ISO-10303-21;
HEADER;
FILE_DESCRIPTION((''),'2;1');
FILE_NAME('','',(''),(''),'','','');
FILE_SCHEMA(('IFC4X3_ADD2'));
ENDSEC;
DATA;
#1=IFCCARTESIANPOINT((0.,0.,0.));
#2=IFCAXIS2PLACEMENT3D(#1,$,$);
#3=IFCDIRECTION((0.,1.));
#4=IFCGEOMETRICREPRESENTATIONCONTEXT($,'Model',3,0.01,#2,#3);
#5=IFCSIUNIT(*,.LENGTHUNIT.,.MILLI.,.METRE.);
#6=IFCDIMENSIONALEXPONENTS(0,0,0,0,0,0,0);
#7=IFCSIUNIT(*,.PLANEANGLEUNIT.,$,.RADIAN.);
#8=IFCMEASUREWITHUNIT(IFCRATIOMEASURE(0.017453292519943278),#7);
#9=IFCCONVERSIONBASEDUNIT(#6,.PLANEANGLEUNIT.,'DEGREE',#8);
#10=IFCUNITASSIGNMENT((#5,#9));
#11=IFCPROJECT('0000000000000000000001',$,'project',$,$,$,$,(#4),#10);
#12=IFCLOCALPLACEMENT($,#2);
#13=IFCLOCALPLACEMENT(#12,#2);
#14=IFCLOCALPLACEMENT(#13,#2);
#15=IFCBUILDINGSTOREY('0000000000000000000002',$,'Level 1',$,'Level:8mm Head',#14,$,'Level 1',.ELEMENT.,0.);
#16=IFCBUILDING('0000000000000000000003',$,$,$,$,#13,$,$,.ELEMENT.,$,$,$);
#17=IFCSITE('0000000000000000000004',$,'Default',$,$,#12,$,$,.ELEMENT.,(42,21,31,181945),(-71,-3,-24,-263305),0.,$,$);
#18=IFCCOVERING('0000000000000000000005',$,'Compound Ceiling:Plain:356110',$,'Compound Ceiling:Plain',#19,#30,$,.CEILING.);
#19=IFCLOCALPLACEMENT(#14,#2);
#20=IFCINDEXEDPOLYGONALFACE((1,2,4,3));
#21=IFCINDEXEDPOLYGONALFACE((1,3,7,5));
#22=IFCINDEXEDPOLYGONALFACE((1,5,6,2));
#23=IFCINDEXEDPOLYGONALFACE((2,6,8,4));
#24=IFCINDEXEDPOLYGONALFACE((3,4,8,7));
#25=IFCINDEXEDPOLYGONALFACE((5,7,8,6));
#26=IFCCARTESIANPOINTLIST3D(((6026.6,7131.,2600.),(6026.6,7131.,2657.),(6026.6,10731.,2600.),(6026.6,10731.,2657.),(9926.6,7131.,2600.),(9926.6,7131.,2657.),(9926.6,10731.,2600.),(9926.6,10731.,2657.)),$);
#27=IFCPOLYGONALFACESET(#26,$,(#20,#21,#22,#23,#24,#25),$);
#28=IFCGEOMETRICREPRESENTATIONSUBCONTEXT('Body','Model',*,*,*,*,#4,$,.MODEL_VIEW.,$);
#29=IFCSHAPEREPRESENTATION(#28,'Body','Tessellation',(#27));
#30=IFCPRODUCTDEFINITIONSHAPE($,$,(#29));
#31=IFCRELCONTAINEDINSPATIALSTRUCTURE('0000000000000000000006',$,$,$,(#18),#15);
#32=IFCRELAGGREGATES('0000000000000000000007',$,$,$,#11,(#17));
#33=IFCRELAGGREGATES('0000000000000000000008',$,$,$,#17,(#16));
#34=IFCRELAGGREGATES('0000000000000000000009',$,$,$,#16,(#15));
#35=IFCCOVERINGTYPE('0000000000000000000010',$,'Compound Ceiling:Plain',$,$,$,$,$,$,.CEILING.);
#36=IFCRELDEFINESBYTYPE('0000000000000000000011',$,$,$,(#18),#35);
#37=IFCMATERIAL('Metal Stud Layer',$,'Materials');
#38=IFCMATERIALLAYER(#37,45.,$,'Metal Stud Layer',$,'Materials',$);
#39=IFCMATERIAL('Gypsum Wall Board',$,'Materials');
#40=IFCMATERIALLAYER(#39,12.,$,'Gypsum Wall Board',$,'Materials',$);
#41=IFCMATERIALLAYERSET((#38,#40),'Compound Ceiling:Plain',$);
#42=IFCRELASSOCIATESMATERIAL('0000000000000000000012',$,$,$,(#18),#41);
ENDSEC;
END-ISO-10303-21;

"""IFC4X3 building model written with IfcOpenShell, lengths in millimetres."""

from ifc_helpers import new_model, entity, si_unit, converted_unit, direction, frame, frame_2d, origin, place, context, subcontext, project, spatial, rectangle, extrude, material, layer, layer_set, layer_usage, type_object, element, save


model = new_model("IFC4X3")

# Units and contexts
model_context = context("Model", 3, precision=0.01, world=origin(), true_north=direction((0.0, 1.0)))
body_context = subcontext(model_context, "Body", "Model", "MODEL_VIEW")
ifc_project = project(units=[si_unit("LENGTHUNIT", "METRE", prefix="MILLI"), converted_unit("PLANEANGLEUNIT", "DEGREE", entity("IfcRatioMeasure", 0.017453292519943278), si_unit("PLANEANGLEUNIT", "RADIAN"), dimensions=[0, 0, 0, 0, 0, 0, 0])], contexts=[model_context])

# Site, building, storey
site_placement = place(None, origin())
site = spatial("IfcSite", under=ifc_project, at=site_placement, Name="Default", CompositionType="ELEMENT", RefLatitude=(42, 21, 31, 181945), RefLongitude=(-71, -3, -24, -263305), RefElevation=0.0)
building_placement = place(site_placement, origin())
building = spatial("IfcBuilding", under=site, at=building_placement, CompositionType="ELEMENT")
storey_placement = place(building_placement, origin())
storey = spatial("IfcBuildingStorey", under=building, at=storey_placement, Name="Level 1", ObjectType="Level:8mm Head", LongName="Level 1", CompositionType="ELEMENT", Elevation=0.0)

# Covering
ifc_material_1 = material(Name="Metal Stud Layer", Category="Materials")
ifc_layer_1 = layer(ifc_material_1, 45.0, Name="Metal Stud Layer", Category="Materials")
ifc_material_2 = material(Name="Gypsum Wall Board", Category="Materials")
ifc_layer_2 = layer(ifc_material_2, 12.0, Name="Gypsum Wall Board", Category="Materials")
ifc_layer_set_1 = layer_set([ifc_layer_1, ifc_layer_2], Name="Compound Ceiling:Plain")
ifc_layer_usage_1 = layer_usage(ifc_layer_set_1, "AXIS3", "POSITIVE", 0.0)
covering_type = type_object("IfcCoveringType", Name="Compound Ceiling:Plain", PredefinedType="CEILING")
covering_placement = place(storey_placement, frame((6026.6, 7131.0, 2600.0)))
element("IfcCovering", 1, at=covering_placement, inside=storey, type_object=covering_type, material=ifc_layer_usage_1, Name="Compound Ceiling:Plain:356110", ObjectType="Compound Ceiling:Plain", PredefinedType="CEILING", context=body_context, shape_type="SweptSolid", body=[
    extrude(rectangle(XDim=3900.0, YDim=3600.0, at=frame_2d((0.0, 0.0), x_axis=(1.0, 0.0))), frame((1950.0, 1800.0, 0.0)), (0.0, 0.0, 1.0), 57.0),
])

save(model, "model.ifc")
